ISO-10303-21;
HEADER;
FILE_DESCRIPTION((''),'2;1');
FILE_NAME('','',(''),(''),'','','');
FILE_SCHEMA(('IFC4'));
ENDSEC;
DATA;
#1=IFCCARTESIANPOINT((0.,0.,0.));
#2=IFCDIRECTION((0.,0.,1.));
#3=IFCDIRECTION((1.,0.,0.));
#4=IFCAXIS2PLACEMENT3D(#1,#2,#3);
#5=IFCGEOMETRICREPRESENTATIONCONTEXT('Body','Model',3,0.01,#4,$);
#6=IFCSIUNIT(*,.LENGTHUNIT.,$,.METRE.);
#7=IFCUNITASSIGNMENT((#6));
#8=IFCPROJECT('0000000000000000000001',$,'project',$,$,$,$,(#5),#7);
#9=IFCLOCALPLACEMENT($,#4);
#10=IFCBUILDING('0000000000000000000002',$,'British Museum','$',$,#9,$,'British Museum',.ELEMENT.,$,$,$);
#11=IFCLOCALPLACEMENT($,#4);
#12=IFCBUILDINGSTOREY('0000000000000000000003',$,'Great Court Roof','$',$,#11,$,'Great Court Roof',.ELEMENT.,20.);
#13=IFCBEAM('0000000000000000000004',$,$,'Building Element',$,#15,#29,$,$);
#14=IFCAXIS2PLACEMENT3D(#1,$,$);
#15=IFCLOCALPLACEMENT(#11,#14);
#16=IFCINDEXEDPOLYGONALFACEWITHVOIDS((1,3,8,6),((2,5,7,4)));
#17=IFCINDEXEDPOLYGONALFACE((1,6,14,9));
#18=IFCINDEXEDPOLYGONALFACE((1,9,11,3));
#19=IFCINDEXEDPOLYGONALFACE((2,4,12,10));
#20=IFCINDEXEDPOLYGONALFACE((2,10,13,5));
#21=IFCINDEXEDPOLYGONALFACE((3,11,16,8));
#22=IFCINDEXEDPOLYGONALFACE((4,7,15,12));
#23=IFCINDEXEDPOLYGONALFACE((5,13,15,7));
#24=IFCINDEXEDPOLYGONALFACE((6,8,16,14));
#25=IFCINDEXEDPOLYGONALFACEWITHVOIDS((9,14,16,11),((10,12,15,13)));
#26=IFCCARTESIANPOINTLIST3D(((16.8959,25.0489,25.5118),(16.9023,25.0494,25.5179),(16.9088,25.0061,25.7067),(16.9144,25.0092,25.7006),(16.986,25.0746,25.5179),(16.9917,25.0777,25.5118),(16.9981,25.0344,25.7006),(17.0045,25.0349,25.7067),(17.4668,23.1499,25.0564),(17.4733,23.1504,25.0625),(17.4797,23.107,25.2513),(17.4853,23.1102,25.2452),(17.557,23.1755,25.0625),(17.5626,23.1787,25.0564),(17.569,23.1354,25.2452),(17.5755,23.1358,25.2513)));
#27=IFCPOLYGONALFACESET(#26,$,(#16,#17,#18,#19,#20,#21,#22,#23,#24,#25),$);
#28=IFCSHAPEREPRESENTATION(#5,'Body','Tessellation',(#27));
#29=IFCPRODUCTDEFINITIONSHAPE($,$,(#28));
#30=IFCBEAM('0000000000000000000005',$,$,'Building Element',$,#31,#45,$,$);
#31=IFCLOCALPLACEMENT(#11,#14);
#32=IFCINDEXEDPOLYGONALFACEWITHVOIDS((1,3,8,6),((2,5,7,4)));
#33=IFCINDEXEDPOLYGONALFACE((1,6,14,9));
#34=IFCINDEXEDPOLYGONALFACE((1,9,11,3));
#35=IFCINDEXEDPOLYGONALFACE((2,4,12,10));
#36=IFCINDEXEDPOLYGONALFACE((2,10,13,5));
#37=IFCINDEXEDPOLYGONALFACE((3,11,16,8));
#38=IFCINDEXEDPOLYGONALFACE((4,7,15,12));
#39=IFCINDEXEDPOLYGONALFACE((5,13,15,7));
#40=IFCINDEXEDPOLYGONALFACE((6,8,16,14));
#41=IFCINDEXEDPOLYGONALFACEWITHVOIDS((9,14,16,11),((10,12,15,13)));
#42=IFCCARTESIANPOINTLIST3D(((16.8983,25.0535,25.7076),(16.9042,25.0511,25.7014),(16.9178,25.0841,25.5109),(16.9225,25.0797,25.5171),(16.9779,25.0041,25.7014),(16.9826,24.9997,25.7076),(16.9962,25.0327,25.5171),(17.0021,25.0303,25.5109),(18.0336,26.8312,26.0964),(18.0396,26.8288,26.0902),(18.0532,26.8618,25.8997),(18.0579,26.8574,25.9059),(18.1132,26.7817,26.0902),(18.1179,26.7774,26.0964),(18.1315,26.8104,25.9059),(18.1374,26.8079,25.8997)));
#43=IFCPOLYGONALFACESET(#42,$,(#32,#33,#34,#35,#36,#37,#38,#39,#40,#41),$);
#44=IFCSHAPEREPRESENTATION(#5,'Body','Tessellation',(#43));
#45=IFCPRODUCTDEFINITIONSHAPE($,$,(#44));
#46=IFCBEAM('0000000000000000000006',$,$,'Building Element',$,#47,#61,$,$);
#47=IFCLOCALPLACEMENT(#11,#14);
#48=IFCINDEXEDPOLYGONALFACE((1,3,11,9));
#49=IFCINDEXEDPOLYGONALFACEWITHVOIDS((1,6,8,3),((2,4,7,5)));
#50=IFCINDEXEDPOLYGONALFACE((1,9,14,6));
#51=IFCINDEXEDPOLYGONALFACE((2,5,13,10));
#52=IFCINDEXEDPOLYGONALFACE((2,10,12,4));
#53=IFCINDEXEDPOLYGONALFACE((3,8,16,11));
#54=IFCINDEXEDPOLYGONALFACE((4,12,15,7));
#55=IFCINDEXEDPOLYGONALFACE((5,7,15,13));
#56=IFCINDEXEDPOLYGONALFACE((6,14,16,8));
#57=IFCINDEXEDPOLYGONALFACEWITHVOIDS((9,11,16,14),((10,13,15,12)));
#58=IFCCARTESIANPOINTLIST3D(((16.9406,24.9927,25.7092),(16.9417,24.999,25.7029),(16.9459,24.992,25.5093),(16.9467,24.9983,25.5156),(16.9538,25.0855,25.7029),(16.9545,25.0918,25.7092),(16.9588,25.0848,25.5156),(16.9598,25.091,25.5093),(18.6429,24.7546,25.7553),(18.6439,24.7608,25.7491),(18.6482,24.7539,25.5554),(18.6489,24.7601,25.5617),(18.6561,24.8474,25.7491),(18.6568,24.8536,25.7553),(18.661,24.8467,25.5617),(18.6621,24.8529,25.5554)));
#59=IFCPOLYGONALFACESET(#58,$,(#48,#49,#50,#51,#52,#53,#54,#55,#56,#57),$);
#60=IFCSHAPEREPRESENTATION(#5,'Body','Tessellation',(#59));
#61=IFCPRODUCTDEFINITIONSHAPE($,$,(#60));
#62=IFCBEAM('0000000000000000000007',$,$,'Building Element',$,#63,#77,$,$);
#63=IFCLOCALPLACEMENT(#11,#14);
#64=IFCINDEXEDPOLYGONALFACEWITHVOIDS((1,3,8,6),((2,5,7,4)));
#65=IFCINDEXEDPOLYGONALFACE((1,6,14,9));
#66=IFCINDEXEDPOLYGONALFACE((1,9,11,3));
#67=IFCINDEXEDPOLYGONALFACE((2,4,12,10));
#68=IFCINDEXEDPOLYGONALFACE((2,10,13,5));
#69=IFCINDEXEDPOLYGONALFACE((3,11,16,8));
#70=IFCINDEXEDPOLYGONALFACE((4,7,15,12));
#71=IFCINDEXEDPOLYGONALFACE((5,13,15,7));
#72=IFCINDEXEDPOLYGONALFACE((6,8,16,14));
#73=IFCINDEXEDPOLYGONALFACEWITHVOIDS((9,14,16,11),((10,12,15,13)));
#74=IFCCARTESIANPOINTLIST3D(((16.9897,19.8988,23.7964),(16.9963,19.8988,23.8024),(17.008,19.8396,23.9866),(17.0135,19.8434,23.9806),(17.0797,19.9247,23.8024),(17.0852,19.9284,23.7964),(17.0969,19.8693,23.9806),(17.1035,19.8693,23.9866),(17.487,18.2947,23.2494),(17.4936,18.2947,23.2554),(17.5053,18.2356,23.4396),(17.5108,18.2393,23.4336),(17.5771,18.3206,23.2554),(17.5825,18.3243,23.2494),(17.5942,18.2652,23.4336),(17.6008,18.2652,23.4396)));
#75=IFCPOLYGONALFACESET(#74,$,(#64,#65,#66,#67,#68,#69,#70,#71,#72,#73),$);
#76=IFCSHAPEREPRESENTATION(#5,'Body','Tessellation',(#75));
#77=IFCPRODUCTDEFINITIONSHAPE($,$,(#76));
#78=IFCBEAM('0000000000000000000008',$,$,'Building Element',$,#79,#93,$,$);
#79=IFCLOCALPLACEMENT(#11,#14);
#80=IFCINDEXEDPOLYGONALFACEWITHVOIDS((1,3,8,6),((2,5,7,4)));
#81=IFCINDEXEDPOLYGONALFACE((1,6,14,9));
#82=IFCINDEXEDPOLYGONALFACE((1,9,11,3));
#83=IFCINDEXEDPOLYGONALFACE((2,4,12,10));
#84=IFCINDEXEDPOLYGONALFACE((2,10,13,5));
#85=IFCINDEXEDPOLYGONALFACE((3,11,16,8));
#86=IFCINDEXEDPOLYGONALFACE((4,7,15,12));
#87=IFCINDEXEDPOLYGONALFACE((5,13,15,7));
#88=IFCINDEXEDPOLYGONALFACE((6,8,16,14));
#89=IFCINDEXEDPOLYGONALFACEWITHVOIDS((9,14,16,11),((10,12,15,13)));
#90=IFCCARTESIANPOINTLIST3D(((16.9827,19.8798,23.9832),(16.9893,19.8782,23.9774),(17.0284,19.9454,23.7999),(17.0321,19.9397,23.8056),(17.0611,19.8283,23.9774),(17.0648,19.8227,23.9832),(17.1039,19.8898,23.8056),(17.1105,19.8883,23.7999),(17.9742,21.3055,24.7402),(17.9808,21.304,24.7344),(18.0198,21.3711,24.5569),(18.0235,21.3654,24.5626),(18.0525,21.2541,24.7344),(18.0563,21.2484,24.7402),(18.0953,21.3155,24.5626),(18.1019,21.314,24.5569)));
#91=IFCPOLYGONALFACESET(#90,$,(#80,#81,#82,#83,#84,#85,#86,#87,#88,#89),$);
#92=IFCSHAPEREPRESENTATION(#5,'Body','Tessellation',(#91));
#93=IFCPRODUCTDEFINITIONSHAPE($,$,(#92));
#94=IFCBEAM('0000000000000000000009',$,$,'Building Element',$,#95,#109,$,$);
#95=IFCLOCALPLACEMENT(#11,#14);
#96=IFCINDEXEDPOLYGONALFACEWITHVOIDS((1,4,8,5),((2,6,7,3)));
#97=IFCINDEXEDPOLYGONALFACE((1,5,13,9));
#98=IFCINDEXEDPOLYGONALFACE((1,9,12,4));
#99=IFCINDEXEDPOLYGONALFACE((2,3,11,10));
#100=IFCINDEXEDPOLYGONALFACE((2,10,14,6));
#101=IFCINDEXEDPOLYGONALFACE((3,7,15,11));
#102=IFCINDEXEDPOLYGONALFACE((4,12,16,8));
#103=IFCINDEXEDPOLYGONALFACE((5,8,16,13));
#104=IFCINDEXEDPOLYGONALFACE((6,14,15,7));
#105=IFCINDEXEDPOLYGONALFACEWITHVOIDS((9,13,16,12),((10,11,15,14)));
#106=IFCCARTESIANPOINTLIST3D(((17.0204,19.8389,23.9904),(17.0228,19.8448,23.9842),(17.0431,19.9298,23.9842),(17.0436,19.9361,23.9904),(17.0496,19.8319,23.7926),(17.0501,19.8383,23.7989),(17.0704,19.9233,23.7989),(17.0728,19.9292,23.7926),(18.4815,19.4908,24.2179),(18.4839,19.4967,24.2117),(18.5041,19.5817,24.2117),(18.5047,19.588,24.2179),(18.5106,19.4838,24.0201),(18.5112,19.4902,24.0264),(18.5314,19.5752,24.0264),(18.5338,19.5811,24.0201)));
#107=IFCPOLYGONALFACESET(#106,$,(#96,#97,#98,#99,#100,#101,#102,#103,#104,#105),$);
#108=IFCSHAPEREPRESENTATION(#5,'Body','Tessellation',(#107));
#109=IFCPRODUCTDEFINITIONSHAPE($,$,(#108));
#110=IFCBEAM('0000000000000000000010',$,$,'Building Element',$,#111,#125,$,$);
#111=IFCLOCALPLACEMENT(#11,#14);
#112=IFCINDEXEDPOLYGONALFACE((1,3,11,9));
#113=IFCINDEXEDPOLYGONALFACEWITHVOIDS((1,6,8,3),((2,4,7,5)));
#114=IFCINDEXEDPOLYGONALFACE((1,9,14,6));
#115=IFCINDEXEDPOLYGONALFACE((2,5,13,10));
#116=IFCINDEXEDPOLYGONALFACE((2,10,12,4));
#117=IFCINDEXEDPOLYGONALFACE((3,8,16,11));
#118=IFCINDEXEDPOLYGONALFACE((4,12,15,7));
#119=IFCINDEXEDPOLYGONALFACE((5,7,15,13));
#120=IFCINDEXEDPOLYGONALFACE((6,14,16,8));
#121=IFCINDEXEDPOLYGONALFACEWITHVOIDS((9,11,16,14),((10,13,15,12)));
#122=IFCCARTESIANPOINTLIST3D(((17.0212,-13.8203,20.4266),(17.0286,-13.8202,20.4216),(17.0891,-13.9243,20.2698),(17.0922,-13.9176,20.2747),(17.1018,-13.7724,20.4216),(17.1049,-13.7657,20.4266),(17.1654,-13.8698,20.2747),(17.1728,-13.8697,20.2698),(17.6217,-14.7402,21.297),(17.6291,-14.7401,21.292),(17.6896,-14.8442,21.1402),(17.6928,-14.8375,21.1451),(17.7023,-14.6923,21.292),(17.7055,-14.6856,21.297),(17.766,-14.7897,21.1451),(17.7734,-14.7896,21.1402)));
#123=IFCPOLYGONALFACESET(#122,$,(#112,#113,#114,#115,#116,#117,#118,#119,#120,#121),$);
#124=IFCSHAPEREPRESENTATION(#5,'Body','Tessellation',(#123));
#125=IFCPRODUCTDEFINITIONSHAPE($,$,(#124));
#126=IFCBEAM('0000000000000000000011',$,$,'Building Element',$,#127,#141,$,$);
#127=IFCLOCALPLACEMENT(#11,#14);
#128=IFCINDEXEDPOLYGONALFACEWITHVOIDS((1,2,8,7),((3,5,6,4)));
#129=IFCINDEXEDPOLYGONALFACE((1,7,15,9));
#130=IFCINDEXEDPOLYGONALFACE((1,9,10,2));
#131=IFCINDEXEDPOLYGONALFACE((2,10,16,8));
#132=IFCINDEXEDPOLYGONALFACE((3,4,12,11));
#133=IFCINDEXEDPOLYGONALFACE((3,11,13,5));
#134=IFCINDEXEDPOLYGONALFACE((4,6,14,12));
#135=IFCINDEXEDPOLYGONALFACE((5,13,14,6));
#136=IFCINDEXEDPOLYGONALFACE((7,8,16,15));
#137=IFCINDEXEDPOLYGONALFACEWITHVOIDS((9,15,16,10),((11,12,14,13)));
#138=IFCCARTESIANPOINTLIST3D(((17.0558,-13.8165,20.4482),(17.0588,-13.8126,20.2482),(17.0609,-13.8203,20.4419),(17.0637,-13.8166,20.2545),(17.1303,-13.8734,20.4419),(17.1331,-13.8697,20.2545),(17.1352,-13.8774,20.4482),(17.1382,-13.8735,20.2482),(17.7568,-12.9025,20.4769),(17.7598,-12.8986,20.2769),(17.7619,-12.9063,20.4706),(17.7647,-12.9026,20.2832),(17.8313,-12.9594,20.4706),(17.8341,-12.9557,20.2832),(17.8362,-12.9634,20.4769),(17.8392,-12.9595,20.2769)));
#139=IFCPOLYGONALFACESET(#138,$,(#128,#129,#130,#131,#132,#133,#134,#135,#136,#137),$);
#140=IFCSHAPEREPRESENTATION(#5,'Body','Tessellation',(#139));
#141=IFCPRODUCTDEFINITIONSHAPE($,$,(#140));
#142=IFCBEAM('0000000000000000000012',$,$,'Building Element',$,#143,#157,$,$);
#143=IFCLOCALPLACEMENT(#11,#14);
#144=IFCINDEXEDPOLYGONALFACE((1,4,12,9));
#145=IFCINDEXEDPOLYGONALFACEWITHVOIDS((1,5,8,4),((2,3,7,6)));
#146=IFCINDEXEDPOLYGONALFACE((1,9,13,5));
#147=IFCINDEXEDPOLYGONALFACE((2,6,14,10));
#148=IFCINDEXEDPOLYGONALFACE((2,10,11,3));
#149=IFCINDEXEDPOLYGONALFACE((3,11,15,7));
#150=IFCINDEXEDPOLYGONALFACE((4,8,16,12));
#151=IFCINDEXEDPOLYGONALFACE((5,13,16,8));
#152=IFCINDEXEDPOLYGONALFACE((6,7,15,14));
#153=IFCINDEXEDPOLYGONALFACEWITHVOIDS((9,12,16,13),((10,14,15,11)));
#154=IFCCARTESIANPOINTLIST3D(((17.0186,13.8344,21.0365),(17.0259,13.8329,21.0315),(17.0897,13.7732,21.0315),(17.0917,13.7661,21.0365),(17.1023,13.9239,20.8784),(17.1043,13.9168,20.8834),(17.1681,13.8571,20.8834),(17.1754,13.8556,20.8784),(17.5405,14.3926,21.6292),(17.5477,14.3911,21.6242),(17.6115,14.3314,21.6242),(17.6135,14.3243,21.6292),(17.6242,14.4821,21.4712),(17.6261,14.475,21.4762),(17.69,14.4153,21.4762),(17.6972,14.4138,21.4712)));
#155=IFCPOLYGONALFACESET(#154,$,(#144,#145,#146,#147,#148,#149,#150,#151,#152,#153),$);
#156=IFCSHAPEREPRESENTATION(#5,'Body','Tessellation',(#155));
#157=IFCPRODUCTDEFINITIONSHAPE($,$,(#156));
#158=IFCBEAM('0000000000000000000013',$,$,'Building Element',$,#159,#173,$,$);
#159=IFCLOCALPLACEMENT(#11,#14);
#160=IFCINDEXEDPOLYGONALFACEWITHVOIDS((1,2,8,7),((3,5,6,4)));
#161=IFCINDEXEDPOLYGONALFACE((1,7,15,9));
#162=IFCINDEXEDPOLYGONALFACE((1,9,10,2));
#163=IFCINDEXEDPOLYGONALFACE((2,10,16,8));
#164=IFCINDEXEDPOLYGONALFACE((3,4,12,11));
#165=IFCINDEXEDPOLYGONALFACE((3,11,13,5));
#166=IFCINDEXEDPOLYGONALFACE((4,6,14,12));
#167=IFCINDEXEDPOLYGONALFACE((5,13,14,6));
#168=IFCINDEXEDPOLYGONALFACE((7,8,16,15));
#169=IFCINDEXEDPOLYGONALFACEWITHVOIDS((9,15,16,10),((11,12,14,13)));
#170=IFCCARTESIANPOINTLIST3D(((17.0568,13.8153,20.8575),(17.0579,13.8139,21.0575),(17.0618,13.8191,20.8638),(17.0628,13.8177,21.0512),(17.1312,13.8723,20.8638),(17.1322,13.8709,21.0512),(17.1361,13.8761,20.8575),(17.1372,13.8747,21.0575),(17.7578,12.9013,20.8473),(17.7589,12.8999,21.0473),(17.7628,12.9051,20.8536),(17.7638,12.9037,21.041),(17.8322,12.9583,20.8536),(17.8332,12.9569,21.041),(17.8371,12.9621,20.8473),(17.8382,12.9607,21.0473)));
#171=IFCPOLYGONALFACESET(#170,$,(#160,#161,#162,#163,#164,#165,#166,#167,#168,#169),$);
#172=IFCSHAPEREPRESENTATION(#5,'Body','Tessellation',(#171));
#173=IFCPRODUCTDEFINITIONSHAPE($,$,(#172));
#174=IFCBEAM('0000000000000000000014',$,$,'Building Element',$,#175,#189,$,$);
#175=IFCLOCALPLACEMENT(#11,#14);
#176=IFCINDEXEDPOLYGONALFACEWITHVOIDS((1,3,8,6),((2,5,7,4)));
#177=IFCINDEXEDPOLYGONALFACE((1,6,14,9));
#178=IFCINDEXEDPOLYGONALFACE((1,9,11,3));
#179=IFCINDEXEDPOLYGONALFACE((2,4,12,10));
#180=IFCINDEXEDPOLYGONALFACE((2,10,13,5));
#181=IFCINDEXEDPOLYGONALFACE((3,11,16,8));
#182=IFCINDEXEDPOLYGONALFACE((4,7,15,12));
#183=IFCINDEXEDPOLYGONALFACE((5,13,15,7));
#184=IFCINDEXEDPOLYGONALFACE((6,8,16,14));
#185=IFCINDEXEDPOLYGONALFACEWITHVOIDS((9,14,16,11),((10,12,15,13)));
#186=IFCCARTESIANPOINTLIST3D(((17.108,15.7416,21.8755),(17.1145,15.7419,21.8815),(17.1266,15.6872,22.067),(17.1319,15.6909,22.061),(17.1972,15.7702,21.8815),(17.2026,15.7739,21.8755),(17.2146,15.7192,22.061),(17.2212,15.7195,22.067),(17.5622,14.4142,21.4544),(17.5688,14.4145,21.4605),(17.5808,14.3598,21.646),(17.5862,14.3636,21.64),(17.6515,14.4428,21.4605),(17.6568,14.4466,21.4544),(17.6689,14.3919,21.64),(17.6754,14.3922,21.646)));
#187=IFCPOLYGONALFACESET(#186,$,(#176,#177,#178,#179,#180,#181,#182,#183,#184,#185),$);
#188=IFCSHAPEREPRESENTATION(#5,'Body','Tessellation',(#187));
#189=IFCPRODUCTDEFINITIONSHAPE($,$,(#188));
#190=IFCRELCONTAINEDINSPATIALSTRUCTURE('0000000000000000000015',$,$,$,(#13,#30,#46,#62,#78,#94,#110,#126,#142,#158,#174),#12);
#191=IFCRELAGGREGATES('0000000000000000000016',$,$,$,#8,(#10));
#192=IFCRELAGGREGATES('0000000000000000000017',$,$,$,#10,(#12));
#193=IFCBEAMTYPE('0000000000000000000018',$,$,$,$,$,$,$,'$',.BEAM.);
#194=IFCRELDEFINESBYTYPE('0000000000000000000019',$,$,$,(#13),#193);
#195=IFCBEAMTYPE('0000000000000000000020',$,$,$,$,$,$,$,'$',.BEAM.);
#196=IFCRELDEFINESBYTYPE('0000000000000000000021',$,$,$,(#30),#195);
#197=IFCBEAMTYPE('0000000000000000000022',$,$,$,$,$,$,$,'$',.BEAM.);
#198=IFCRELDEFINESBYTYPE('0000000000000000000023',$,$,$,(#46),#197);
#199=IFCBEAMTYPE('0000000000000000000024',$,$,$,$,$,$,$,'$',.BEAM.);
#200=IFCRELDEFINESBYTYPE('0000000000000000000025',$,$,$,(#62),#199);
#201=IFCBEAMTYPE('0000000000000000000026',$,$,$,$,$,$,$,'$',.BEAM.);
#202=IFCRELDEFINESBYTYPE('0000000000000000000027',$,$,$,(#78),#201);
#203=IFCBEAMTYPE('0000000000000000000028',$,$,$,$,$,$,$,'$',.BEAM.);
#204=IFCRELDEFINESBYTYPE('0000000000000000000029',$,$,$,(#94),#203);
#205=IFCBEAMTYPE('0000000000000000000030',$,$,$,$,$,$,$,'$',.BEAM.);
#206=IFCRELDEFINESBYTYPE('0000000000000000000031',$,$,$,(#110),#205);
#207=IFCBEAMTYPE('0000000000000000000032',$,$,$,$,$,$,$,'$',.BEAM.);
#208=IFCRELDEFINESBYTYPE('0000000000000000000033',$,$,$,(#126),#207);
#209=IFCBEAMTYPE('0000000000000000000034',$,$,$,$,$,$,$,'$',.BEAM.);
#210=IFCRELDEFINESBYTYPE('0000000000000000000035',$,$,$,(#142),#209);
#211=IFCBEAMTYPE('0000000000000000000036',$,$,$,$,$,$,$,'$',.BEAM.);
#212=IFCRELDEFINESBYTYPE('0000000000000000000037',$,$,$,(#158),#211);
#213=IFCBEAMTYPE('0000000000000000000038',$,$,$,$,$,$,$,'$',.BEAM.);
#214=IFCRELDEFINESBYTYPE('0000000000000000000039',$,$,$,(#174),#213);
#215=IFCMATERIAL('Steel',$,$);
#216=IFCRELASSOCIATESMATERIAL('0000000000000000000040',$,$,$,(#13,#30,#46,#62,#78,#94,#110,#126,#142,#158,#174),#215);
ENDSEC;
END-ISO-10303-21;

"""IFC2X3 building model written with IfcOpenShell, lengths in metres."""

from ifc_helpers import new_model, si_unit, frame, origin_with_axes, origin_2d, place, context, project, spatial, hollow_rectangle, extrude, material, type_object, element, save


model = new_model("IFC2X3")

# Units and contexts
model_context = context("Model", 3, precision=0.01, world=origin_with_axes(), identifier="Body")
ifc_project = project(units=[si_unit("LENGTHUNIT", "METRE")], contexts=[model_context])

# Building, storey
building_placement = place(None, origin_with_axes())
building = spatial("IfcBuilding", under=ifc_project, at=building_placement, Name="British Museum", Description="$", LongName="British Museum", CompositionType="ELEMENT")
storey_placement = place(None, origin_with_axes())
storey = spatial("IfcBuildingStorey", under=building, at=storey_placement, Name="Great Court Roof", Description="$", LongName="Great Court Roof", CompositionType="ELEMENT", Elevation=20.0)

# Beams
ifc_material = material(Name="Steel")
beam_type_1 = type_object("IfcBeamType", ElementType="$", PredefinedType="BEAM")
beam_1_placement = place(None, origin_with_axes())
element("IfcBeam", 1, at=beam_1_placement, inside=storey, type_object=beam_type_1, material=ifc_material, Description="Building Element", context=model_context, shape_type="SweptSolid", body=[
    extrude(hollow_rectangle(XDim=0.1, YDim=0.2, WallThickness=0.0063, InnerFilletRadius=0.0, OuterFilletRadius=0.0, at=origin_2d()), frame((16.9502, 25.0419, 25.6093), z_axis=(0.280613, -0.933356, -0.223835), x_axis=(0.957655, 0.287919, 0.0)), (0.0, 0.0, 1.0), 2.0346),
])
beam_type_2 = type_object("IfcBeamType", ElementType="$", PredefinedType="BEAM")
beam_2_placement = place(None, origin_with_axes())
element("IfcBeam", 2, at=beam_2_placement, inside=storey, type_object=beam_type_2, material=ifc_material, Description="Building Element", context=model_context, shape_type="SweptSolid", body=[
    extrude(hollow_rectangle(XDim=0.1, YDim=0.2, WallThickness=0.0063, InnerFilletRadius=0.0, OuterFilletRadius=0.0, at=origin_2d()), frame((16.9502, 25.0419, 25.6093), z_axis=(0.529335, 0.828823, 0.181266), x_axis=(-0.842784, 0.538252, 0.0)), (0.0, 0.0, 1.0), 2.1448),
])
beam_type_3 = type_object("IfcBeamType", ElementType="$", PredefinedType="BEAM")
beam_3_placement = place(None, origin_with_axes())
element("IfcBeam", 3, at=beam_3_placement, inside=storey, type_object=beam_type_3, material=ifc_material, Description="Building Element", context=model_context, shape_type="SweptSolid", body=[
    extrude(hollow_rectangle(XDim=0.1, YDim=0.2, WallThickness=0.0063, InnerFilletRadius=0.0, OuterFilletRadius=0.0, at=origin_2d()), frame((16.9502, 25.0419, 25.6093), z_axis=(0.989999, -0.138498, 0.026827), x_axis=(0.138548, 0.990356, 0.0)), (0.0, 0.0, 1.0), 1.7195),
])
beam_type_4 = type_object("IfcBeamType", ElementType="$", PredefinedType="BEAM")
beam_4_placement = place(None, origin_with_axes())
element("IfcBeam", 4, at=beam_4_placement, inside=storey, type_object=beam_type_4, material=ifc_material, Description="Building Element", context=model_context, shape_type="SweptSolid", body=[
    extrude(hollow_rectangle(XDim=0.1, YDim=0.2, WallThickness=0.0063, InnerFilletRadius=0.0, OuterFilletRadius=0.0, at=origin_2d()), frame((17.0466, 19.884, 23.8915), z_axis=(0.281566, -0.908189, -0.309698), x_axis=(0.955149, 0.296124, 0.0)), (0.0, 0.0, 1.0), 1.7662),
])
beam_type_5 = type_object("IfcBeamType", ElementType="$", PredefinedType="BEAM")
beam_5_placement = place(None, origin_with_axes())
element("IfcBeam", 5, at=beam_5_placement, inside=storey, type_object=beam_type_5, material=ifc_material, Description="Building Element", context=model_context, shape_type="SweptSolid", body=[
    extrude(hollow_rectangle(XDim=0.1, YDim=0.2, WallThickness=0.0063, InnerFilletRadius=0.0, OuterFilletRadius=0.0, at=origin_2d()), frame((17.0466, 19.884, 23.8915), z_axis=(0.523354, 0.752603, 0.39961), x_axis=(-0.821005, 0.570921, 0.0)), (0.0, 0.0, 1.0), 1.8944),
])
beam_type_6 = type_object("IfcBeamType", ElementType="$", PredefinedType="BEAM")
beam_6_placement = place(None, origin_with_axes())
element("IfcBeam", 6, at=beam_6_placement, inside=storey, type_object=beam_type_6, material=ifc_material, Description="Building Element", context=model_context, shape_type="SweptSolid", body=[
    extrude(hollow_rectangle(XDim=0.1, YDim=0.2, WallThickness=0.0063, InnerFilletRadius=0.0, OuterFilletRadius=0.0, at=origin_2d()), frame((17.0466, 19.884, 23.8915), z_axis=(0.961801, -0.229157, 0.149754), x_axis=(0.23177, 0.972771, 0.0)), (0.0, 0.0, 1.0), 1.5191),
])
beam_type_7 = type_object("IfcBeamType", ElementType="$", PredefinedType="BEAM")
beam_7_placement = place(None, origin_with_axes())
element("IfcBeam", 7, at=beam_7_placement, inside=storey, type_object=beam_type_7, material=ifc_material, Description="Building Element", context=model_context, shape_type="SweptSolid", body=[
    extrude(hollow_rectangle(XDim=0.1, YDim=0.2, WallThickness=0.0063, InnerFilletRadius=0.0, OuterFilletRadius=0.0, at=origin_2d()), frame((17.097, -13.845, 20.3482), z_axis=(0.428479, -0.656326, 0.621001), x_axis=(0.837353, 0.546662, 0.0)), (0.0, 0.0, 1.0), 1.4016),
])
beam_type_8 = type_object("IfcBeamType", ElementType="$", PredefinedType="BEAM")
beam_8_placement = place(None, origin_with_axes())
element("IfcBeam", 8, at=beam_8_placement, inside=storey, type_object=beam_type_8, material=ifc_material, Description="Building Element", context=model_context, shape_type="SweptSolid", body=[
    extrude(hollow_rectangle(XDim=0.1, YDim=0.2, WallThickness=0.0063, InnerFilletRadius=0.0, OuterFilletRadius=0.0, at=origin_2d()), frame((17.097, -13.845, 20.3482), z_axis=(0.608389, 0.793248, 0.024907), x_axis=(-0.793495, 0.608577, 0.0)), (0.0, 0.0, 1.0), 1.1522),
])
beam_type_9 = type_object("IfcBeamType", ElementType="$", PredefinedType="BEAM")
beam_9_placement = place(None, origin_with_axes())
element("IfcBeam", 9, at=beam_9_placement, inside=storey, type_object=beam_type_9, material=ifc_material, Description="Building Element", context=model_context, shape_type="SweptSolid", body=[
    extrude(hollow_rectangle(XDim=0.1, YDim=0.2, WallThickness=0.0063, InnerFilletRadius=0.0, OuterFilletRadius=0.0, at=origin_2d()), frame((17.097, 13.845, 20.9575), z_axis=(0.539594, 0.577201, 0.612925), x_axis=(-0.730504, 0.682909, 0.0)), (0.0, 0.0, 1.0), 0.9671),
])
beam_type_10 = type_object("IfcBeamType", ElementType="$", PredefinedType="BEAM")
beam_10_placement = place(None, origin_with_axes())
element("IfcBeam", 10, at=beam_10_placement, inside=storey, type_object=beam_type_10, material=ifc_material, Description="Building Element", context=model_context, shape_type="SweptSolid", body=[
    extrude(hollow_rectangle(XDim=0.1, YDim=0.2, WallThickness=0.0063, InnerFilletRadius=0.0, OuterFilletRadius=0.0, at=origin_2d()), frame((17.097, 13.845, 20.9575), z_axis=(0.608554, -0.793463, -0.008849), x_axis=(0.793495, 0.608577, 0.0)), (0.0, 0.0, 1.0), 1.1519),
])
beam_type_11 = type_object("IfcBeamType", ElementType="$", PredefinedType="BEAM")
beam_11_placement = place(None, origin_with_axes())
element("IfcBeam", 11, at=beam_11_placement, inside=storey, type_object=beam_type_11, material=ifc_material, Description="Building Element", context=model_context, shape_type="SweptSolid", body=[
    extrude(hollow_rectangle(XDim=0.1, YDim=0.2, WallThickness=0.0063, InnerFilletRadius=0.0, OuterFilletRadius=0.0, at=origin_2d()), frame((17.1646, 15.7306, 21.9712), z_axis=(0.310133, -0.9062, -0.287436), x_axis=(0.946126, 0.323798, 0.0)), (0.0, 0.0, 1.0), 1.4647),
])

save(model, "model.ifc")
